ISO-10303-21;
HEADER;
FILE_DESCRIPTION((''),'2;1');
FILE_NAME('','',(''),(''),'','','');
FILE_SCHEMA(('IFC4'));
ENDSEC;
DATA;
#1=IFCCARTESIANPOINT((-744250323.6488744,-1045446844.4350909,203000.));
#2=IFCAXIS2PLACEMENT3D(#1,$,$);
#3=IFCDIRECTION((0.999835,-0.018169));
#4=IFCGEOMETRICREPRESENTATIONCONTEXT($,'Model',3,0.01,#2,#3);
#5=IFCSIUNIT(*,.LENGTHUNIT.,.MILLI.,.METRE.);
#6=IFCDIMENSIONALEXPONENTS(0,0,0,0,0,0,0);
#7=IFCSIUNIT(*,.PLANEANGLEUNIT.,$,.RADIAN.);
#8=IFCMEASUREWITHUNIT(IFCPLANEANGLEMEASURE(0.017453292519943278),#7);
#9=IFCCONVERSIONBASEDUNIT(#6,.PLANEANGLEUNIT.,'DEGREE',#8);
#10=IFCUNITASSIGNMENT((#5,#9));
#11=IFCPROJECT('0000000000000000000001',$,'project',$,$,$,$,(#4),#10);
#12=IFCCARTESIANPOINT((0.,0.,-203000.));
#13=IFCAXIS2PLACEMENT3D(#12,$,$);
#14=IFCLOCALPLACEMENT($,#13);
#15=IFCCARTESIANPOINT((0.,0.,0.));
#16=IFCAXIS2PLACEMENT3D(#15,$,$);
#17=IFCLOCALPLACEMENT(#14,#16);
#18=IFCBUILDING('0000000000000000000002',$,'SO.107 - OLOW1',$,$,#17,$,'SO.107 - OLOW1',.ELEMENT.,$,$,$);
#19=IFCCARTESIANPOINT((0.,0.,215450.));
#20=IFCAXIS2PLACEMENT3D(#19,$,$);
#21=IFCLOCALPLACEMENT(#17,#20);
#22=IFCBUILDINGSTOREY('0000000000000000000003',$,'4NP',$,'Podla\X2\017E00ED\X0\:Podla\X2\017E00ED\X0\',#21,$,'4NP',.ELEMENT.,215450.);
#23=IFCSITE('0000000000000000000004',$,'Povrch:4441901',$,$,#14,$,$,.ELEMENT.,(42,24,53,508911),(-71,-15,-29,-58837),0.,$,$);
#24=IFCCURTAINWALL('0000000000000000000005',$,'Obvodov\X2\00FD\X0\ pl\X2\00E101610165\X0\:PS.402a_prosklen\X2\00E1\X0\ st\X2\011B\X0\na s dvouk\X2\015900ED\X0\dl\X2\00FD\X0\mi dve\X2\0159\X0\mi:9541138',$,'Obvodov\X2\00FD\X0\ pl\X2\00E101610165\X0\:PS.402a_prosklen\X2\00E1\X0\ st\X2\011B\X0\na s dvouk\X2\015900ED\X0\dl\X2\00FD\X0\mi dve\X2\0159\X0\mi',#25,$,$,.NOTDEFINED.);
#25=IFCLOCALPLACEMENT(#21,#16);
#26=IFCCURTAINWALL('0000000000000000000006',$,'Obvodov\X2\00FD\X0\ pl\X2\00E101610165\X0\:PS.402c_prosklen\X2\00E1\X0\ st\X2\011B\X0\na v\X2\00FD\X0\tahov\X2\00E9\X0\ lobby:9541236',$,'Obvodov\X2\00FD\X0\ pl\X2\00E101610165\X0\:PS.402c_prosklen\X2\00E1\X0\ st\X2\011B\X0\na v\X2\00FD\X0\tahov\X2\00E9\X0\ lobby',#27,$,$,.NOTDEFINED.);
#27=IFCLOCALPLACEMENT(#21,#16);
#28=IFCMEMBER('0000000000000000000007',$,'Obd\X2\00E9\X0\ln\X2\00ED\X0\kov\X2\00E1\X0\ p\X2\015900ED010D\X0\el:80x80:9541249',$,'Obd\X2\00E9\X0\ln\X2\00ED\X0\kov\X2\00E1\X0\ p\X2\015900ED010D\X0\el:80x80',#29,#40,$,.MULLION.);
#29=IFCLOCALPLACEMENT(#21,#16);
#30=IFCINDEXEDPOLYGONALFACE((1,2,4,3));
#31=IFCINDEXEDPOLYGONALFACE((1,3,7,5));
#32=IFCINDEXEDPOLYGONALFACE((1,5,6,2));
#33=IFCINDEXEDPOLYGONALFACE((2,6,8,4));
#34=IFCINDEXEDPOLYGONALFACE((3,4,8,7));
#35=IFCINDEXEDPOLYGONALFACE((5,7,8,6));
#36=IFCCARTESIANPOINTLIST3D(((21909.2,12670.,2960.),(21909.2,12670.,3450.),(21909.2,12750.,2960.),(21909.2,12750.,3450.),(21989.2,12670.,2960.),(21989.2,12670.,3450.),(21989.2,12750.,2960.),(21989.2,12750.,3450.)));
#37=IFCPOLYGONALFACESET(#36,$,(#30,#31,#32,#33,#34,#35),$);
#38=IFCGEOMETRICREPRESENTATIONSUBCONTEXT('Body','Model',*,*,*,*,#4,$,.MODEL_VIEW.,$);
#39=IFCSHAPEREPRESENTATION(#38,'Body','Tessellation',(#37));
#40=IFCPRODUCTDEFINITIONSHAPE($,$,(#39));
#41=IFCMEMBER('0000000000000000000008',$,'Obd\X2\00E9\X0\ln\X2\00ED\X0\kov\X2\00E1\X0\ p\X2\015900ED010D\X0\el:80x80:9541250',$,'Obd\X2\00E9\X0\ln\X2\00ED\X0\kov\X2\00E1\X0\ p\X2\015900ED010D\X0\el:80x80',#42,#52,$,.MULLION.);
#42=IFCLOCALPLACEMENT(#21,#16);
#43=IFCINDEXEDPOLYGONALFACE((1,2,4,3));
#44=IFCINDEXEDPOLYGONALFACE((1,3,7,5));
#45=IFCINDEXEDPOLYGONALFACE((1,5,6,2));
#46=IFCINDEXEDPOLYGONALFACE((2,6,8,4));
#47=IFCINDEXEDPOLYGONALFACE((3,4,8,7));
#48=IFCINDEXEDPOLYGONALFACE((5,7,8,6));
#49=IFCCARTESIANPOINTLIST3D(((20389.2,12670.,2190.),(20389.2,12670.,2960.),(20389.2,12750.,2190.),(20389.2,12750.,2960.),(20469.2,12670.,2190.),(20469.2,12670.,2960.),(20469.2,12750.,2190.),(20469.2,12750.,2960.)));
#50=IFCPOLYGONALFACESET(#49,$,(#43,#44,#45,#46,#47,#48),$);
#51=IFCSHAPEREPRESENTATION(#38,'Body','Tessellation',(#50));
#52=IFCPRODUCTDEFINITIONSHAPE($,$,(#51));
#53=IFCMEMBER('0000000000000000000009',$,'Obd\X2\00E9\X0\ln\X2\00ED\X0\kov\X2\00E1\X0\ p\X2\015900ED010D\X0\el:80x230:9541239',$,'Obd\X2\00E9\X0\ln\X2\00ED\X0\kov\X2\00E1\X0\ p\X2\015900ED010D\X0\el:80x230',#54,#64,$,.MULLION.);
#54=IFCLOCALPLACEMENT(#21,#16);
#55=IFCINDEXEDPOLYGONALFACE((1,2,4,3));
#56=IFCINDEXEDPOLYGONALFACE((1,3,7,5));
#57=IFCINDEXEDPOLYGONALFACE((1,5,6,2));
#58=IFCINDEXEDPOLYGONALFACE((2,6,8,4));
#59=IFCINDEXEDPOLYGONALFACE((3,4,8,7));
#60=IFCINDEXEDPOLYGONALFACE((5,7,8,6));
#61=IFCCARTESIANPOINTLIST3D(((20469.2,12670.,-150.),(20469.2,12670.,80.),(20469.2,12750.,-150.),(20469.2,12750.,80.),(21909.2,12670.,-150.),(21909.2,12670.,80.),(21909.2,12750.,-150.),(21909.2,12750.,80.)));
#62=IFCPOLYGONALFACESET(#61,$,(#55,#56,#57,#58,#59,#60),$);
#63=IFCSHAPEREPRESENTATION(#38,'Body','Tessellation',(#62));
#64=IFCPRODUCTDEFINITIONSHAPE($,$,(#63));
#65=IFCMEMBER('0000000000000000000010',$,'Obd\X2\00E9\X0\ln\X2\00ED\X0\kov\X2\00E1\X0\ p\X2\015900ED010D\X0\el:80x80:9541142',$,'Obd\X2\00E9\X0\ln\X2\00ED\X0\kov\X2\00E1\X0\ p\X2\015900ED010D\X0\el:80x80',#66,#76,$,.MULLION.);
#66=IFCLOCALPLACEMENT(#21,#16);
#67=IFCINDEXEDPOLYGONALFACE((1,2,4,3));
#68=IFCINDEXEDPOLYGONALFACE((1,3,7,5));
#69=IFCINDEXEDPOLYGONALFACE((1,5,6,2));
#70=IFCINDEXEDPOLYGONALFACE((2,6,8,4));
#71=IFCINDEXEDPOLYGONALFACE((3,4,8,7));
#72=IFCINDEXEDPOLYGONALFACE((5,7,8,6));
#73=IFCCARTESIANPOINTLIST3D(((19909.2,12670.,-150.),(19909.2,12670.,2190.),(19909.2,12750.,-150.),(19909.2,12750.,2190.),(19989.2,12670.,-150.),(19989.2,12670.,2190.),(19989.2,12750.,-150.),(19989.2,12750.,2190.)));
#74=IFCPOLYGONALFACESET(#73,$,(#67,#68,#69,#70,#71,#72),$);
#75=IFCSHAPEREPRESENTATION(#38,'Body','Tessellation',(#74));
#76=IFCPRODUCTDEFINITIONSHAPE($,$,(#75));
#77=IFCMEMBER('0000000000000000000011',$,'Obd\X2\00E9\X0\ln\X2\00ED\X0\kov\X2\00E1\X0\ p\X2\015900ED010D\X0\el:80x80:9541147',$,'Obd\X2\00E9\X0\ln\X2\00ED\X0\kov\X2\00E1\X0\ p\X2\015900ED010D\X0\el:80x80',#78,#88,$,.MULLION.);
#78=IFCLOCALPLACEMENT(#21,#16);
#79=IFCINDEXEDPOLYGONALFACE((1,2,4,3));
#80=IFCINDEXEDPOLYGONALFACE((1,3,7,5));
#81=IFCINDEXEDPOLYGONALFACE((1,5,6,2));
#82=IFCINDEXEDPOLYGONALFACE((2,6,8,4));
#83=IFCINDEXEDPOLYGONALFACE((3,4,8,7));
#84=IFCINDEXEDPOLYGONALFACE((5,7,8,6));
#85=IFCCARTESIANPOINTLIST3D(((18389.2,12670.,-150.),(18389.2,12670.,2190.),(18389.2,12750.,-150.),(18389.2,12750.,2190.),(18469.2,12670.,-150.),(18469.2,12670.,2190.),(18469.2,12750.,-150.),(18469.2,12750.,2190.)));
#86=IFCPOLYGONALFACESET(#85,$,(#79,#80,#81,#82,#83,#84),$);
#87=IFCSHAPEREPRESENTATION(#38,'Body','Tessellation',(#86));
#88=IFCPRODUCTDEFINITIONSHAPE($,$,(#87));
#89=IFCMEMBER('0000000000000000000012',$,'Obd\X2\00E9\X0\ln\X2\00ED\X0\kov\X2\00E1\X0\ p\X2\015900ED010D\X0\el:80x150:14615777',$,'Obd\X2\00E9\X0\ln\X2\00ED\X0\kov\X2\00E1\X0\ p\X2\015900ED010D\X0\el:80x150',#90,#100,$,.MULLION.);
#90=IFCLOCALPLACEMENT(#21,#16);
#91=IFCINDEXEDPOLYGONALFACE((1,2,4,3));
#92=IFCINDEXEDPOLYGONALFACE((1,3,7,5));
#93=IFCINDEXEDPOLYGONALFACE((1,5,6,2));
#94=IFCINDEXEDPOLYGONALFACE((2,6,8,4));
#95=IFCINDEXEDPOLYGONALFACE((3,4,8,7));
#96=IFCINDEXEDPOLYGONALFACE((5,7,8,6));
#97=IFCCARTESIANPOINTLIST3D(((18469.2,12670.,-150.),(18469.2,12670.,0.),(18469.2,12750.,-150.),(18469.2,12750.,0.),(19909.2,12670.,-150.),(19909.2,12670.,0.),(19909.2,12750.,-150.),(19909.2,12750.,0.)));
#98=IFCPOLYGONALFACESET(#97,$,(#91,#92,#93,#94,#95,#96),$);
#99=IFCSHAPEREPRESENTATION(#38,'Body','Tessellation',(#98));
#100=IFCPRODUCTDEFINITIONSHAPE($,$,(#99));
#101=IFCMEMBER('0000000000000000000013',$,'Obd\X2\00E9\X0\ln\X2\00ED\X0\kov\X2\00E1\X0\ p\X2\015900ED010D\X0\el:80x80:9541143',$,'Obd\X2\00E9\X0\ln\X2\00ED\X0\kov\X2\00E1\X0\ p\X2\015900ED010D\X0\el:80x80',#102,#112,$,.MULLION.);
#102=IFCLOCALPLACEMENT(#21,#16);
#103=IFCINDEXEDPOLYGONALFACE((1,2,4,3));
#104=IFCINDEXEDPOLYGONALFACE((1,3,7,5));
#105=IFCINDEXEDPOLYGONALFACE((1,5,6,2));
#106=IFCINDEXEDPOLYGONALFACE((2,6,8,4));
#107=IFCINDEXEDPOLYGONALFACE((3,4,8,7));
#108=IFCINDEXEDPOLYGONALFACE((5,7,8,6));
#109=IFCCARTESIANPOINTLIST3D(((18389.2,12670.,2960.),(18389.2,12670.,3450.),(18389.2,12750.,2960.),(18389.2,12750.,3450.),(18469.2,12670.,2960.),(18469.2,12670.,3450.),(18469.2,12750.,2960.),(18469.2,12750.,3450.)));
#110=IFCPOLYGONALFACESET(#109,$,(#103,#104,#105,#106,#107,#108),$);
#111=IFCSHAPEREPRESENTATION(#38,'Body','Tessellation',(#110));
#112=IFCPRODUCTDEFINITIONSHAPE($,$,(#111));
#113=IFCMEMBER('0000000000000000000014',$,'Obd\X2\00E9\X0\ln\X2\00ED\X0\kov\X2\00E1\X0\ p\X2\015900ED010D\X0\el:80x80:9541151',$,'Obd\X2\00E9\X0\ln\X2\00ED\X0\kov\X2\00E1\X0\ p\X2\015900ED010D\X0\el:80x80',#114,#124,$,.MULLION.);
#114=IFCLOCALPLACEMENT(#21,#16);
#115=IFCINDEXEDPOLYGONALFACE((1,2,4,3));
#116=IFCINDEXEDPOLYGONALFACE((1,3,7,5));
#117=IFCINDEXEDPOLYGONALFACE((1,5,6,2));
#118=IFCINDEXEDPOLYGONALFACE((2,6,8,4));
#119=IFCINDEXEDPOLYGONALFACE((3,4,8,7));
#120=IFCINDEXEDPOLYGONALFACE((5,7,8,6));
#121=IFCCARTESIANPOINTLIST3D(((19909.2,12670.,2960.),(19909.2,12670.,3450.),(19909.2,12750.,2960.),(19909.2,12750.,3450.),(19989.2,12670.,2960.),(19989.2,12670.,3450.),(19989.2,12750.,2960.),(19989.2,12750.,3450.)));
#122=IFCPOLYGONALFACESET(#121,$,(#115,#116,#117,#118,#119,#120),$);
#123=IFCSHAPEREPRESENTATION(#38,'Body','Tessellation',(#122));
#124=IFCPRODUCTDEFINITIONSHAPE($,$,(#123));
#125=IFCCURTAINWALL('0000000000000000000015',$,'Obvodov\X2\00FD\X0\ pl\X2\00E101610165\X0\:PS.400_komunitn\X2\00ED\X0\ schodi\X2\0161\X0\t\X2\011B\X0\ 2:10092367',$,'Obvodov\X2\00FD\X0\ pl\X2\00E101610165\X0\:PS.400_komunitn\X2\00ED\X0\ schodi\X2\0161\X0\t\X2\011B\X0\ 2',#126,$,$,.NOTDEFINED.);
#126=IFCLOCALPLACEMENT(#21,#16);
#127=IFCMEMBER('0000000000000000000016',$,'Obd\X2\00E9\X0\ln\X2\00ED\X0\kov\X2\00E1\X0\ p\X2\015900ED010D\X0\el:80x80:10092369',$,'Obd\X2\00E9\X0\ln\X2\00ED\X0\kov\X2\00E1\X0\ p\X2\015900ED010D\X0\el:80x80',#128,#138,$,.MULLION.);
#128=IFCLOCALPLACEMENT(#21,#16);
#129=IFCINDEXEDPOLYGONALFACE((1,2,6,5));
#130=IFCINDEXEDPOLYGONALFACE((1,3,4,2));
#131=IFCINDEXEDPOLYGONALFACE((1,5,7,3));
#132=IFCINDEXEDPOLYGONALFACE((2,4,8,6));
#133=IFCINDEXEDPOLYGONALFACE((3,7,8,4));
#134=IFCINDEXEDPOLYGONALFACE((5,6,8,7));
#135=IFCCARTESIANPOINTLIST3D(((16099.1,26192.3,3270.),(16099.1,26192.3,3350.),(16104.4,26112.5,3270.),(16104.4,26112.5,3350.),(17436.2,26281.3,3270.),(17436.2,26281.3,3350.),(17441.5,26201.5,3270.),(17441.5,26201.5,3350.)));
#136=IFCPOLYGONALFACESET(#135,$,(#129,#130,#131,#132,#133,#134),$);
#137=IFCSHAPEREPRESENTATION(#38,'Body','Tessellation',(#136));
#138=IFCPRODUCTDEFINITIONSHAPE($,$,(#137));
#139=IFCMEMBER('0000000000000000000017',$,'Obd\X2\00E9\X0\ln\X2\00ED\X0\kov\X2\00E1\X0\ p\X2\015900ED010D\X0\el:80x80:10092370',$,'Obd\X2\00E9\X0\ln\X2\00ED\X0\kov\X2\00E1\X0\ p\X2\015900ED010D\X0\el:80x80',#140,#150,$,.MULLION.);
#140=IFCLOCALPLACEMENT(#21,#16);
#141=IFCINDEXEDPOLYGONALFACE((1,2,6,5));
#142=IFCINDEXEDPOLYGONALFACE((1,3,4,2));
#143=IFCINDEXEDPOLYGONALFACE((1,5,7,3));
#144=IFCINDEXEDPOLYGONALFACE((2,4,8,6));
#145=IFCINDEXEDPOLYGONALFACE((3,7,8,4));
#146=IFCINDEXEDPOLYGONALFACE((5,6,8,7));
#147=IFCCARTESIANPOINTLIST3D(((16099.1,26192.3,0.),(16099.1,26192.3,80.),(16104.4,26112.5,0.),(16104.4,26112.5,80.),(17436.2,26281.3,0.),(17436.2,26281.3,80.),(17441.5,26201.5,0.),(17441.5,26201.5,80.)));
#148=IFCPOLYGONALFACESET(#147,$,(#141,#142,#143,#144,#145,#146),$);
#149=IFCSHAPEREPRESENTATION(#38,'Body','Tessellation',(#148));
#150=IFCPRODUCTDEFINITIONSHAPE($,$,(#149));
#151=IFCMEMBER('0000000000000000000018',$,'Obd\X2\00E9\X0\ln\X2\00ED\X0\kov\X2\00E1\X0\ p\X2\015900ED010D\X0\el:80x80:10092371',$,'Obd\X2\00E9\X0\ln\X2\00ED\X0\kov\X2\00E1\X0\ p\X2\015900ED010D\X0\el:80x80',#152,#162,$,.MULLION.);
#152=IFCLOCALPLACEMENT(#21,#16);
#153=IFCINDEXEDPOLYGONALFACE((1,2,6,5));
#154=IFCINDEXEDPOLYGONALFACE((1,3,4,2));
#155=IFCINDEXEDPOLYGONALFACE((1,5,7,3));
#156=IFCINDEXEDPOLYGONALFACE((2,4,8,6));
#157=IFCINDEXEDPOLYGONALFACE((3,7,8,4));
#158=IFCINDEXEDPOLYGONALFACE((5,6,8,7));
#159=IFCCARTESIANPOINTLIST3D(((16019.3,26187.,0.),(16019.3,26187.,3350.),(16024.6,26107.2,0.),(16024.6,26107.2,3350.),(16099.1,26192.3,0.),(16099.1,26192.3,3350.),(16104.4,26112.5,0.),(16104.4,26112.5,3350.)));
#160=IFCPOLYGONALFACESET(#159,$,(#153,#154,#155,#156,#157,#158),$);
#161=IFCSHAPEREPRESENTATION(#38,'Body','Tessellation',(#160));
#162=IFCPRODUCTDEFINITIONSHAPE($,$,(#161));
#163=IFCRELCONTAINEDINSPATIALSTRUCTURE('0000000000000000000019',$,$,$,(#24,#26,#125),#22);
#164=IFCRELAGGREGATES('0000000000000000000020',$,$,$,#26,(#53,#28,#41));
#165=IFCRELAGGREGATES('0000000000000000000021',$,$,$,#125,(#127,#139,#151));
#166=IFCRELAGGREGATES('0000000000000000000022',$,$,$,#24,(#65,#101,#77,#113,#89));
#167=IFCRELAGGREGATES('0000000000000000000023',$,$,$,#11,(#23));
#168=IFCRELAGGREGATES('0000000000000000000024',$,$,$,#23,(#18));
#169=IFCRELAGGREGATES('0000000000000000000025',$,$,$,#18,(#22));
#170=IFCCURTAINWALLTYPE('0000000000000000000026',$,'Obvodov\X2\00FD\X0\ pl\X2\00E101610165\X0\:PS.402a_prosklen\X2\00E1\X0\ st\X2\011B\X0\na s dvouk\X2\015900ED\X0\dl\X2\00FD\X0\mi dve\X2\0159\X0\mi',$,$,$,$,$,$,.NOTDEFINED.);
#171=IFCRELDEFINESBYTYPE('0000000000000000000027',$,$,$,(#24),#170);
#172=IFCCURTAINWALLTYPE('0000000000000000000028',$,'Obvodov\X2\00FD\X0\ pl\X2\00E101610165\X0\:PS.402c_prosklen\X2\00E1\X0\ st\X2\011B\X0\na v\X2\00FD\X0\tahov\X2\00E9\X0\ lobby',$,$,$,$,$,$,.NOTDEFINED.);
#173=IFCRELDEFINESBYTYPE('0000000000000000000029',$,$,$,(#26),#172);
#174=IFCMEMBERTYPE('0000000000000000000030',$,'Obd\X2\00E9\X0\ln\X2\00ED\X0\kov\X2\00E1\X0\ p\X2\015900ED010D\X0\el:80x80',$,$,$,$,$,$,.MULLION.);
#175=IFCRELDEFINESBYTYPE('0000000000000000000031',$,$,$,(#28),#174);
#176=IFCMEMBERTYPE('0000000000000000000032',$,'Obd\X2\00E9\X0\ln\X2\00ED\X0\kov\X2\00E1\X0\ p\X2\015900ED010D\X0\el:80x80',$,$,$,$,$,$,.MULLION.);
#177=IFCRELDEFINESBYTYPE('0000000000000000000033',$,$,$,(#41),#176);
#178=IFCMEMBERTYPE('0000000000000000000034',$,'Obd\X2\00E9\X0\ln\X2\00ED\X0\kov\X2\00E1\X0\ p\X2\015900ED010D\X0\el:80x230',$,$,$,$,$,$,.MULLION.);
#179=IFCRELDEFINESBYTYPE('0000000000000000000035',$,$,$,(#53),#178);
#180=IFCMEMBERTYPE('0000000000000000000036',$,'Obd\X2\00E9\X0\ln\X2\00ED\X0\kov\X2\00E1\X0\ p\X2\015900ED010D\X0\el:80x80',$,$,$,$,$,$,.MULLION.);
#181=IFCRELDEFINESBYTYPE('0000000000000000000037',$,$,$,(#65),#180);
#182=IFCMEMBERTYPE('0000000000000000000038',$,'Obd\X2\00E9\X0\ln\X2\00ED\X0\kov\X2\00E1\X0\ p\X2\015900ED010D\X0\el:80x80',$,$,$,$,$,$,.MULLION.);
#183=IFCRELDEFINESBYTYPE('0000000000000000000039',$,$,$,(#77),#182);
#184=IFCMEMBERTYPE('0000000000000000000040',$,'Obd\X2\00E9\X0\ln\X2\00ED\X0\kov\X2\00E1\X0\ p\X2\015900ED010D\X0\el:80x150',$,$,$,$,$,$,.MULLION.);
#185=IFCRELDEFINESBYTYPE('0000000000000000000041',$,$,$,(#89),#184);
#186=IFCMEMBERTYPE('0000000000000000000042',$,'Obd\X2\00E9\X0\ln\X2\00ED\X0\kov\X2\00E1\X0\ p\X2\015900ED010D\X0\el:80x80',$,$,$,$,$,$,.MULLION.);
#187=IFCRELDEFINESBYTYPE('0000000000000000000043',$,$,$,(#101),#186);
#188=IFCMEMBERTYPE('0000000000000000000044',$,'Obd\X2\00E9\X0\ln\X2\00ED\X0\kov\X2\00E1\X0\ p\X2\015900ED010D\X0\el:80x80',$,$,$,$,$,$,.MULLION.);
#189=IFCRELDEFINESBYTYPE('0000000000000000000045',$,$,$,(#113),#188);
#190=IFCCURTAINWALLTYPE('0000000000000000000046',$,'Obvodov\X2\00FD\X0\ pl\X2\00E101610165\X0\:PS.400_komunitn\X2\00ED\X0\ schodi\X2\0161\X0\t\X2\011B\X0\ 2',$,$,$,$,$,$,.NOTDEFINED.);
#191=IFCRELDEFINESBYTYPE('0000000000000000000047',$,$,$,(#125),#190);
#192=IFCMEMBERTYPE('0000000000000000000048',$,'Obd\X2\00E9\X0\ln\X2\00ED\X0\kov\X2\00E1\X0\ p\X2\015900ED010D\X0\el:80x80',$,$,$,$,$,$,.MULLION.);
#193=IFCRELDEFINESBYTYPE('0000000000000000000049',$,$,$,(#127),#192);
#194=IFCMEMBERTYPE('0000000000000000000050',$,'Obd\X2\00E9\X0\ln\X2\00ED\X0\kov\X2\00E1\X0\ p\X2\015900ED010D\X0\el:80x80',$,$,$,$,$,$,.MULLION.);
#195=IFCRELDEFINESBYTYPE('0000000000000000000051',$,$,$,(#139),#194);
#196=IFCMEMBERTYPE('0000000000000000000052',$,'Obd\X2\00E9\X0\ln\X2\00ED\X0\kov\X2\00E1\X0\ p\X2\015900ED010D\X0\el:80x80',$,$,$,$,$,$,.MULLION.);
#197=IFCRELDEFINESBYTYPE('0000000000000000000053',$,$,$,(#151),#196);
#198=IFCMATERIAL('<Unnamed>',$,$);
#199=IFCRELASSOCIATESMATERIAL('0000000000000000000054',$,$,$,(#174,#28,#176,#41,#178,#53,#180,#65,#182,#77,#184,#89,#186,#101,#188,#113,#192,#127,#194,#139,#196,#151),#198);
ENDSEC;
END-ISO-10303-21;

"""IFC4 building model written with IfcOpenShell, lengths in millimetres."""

from ifc_helpers import new_model, entity, si_unit, converted_unit, direction, frame, origin, place, context, subcontext, project, spatial, indexed_curve, outline, extrude, source, transform, mapped, material, type_object, type_shapes, element, aggregate, save


model = new_model("IFC4")

# Units and contexts
model_context = context("Model", 3, precision=0.01, world=frame((-744250323.6488744, -1045446844.4350909, 203000.0)), true_north=direction((0.999835, -0.018169)))
body_context = subcontext(model_context, "Body", "Model", "MODEL_VIEW")
ifc_project = project(units=[si_unit("LENGTHUNIT", "METRE", prefix="MILLI"), converted_unit("PLANEANGLEUNIT", "DEGREE", entity("IfcPlaneAngleMeasure", 0.017453292519943278), si_unit("PLANEANGLEUNIT", "RADIAN"), dimensions=[0, 0, 0, 0, 0, 0, 0])], contexts=[model_context])

# Site, building, storey
site_placement = place(None, frame((0.0, 0.0, -203000.0)))
site = spatial("IfcSite", under=ifc_project, at=site_placement, Name="Povrch:4441901", CompositionType="ELEMENT", RefLatitude=(42, 24, 53, 508911), RefLongitude=(-71, -15, -29, -58837), RefElevation=0.0)
building_placement = place(site_placement, origin())
building = spatial("IfcBuilding", under=site, at=building_placement, Name="SO.107 - OLOW1", LongName="SO.107 - OLOW1", CompositionType="ELEMENT")
storey_placement = place(building_placement, frame((0.0, 0.0, 215450.0)))
storey = spatial("IfcBuildingStorey", under=building, at=storey_placement, Name="4NP", ObjectType="Podlaží:Podlaží", LongName="4NP", CompositionType="ELEMENT", Elevation=215450.0)

# Curtain walls, members
curtain_wall_type_1 = type_object("IfcCurtainWallType", Name="Obvodový plášť:PS.402a_prosklená stěna s dvoukřídlými dveřmi", PredefinedType="NOTDEFINED")
curtain_wall_1_placement = place(storey_placement, frame((0.0, 0.0, -215450.0)))
curtain_wall_1 = element("IfcCurtainWall", 1, at=curtain_wall_1_placement, inside=storey, type_object=curtain_wall_type_1, Name="Obvodový plášť:PS.402a_prosklená stěna s dvoukřídlými dveřmi:9541138", ObjectType="Obvodový plášť:PS.402a_prosklená stěna s dvoukřídlými dveřmi", PredefinedType="NOTDEFINED")
ifc_material_1 = material(Name="<Unnamed>")
curtain_wall_type_2 = type_object("IfcCurtainWallType", Name="Obvodový plášť:PS.402c_prosklená stěna výtahové lobby", PredefinedType="NOTDEFINED")
curtain_wall_2_placement = place(storey_placement, frame((0.0, 0.0, -215450.0)))
curtain_wall_2 = element("IfcCurtainWall", 2, at=curtain_wall_2_placement, inside=storey, type_object=curtain_wall_type_2, Name="Obvodový plášť:PS.402c_prosklená stěna výtahové lobby:9541236", ObjectType="Obvodový plášť:PS.402c_prosklená stěna výtahové lobby", PredefinedType="NOTDEFINED")
member_type_1 = type_object("IfcMemberType", Name="Obdélníková příčel:80x80", PredefinedType="MULLION", material=ifc_material_1)
shared_shape_1 = source(origin(), body_context, "Body", "SweptSolid", [
    extrude(outline(indexed_curve([(-40.0, -40.0), (40.0, -40.0), (40.0, 40.0), (-40.0, 40.0), (-40.0, -40.0)], self_intersect=False)), frame((-40.0, 0.0, -490.0), z_axis=(0.0, 0.0, 1.0), x_axis=(-1.0, 0.0, 0.0)), (0.0, 0.0, 1.0), 490.0),
])
type_shapes(member_type_1, [shared_shape_1])
member_1_placement = place(curtain_wall_2_placement, frame((21989.2, 12710.0, 218410.0), z_axis=(0.0, 0.0, -1.0), x_axis=(1.0, 0.0, 0.0)))
member_1 = element("IfcMember", 3, at=member_1_placement, type_object=member_type_1, material=ifc_material_1, Name="Obdélníková příčel:80x80:9541249", ObjectType="Obdélníková příčel:80x80", PredefinedType="MULLION", context=body_context, shape_type="MappedRepresentation", body=[
    mapped(shared_shape_1, transform((0.0, 0.0, 0.0), scale=1.0)),
])
member_type_2 = type_object("IfcMemberType", Name="Obdélníková příčel:80x80", PredefinedType="MULLION", material=ifc_material_1)
shared_shape_2 = source(origin(), body_context, "Body", "SweptSolid", [
    extrude(outline(indexed_curve([(-40.0, -40.0), (40.0, -40.0), (40.0, 40.0), (-40.0, 40.0), (-40.0, -40.0)], self_intersect=False)), frame((-40.0, 0.0, -770.0), z_axis=(0.0, 0.0, 1.0), x_axis=(-1.0, 0.0, 0.0)), (0.0, 0.0, 1.0), 770.0),
])
type_shapes(member_type_2, [shared_shape_2])
member_2_placement = place(curtain_wall_2_placement, frame((20389.2, 12710.0, 218410.0), z_axis=(0.0, 0.0, 1.0), x_axis=(-1.0, 0.0, 0.0)))
member_2 = element("IfcMember", 4, at=member_2_placement, type_object=member_type_2, material=ifc_material_1, Name="Obdélníková příčel:80x80:9541250", ObjectType="Obdélníková příčel:80x80", PredefinedType="MULLION", context=body_context, shape_type="MappedRepresentation", body=[
    mapped(shared_shape_2, transform((0.0, 0.0, 0.0), scale=1.0)),
])
member_type_3 = type_object("IfcMemberType", Name="Obdélníková příčel:80x230", PredefinedType="MULLION", material=ifc_material_1)
shared_shape_3 = source(origin(), body_context, "Body", "SweptSolid", [
    extrude(outline(indexed_curve([(-115.0, -40.0), (115.0, -40.0), (115.0, 40.0), (-115.0, 40.0), (-115.0, -40.0)], self_intersect=False)), frame((-115.0, 0.0, -1440.0), z_axis=(0.0, 0.0, 1.0), x_axis=(-1.0, 0.0, 0.0)), (0.0, 0.0, 1.0), 1440.0),
])
type_shapes(member_type_3, [shared_shape_3])
member_3_placement = place(curtain_wall_2_placement, frame((20469.2, 12710.0, 215300.0), z_axis=(-1.0, 0.0, 0.0), x_axis=(0.0, 0.0, -1.0)))
member_3 = element("IfcMember", 5, at=member_3_placement, type_object=member_type_3, material=ifc_material_1, Name="Obdélníková příčel:80x230:9541239", ObjectType="Obdélníková příčel:80x230", PredefinedType="MULLION", context=body_context, shape_type="MappedRepresentation", body=[
    mapped(shared_shape_3, transform((0.0, 0.0, 0.0), scale=1.0)),
])

# Members
member_type_4 = type_object("IfcMemberType", Name="Obdélníková příčel:80x80", PredefinedType="MULLION", material=ifc_material_1)
shared_shape_4 = source(origin(), body_context, "Body", "SweptSolid", [
    extrude(outline(indexed_curve([(-40.0, -40.0), (40.0, -40.0), (40.0, 40.0), (-40.0, 40.0), (-40.0, -40.0)], self_intersect=False)), frame((-40.0, 0.0, -2340.0), z_axis=(0.0, 0.0, 1.0), x_axis=(-1.0, 0.0, 0.0)), (0.0, 0.0, 1.0), 2340.0),
])
type_shapes(member_type_4, [shared_shape_4])
member_4_placement = place(curtain_wall_1_placement, frame((19989.2, 12710.0, 215300.0), z_axis=(0.0, 0.0, -1.0), x_axis=(1.0, 0.0, 0.0)))
member_4 = element("IfcMember", 6, at=member_4_placement, type_object=member_type_4, material=ifc_material_1, Name="Obdélníková příčel:80x80:9541142", ObjectType="Obdélníková příčel:80x80", PredefinedType="MULLION", context=body_context, shape_type="MappedRepresentation", body=[
    mapped(shared_shape_4, transform((0.0, 0.0, 0.0), scale=1.0)),
])
member_type_5 = type_object("IfcMemberType", Name="Obdélníková příčel:80x80", PredefinedType="MULLION", material=ifc_material_1)
shared_shape_5 = source(origin(), body_context, "Body", "SweptSolid", [
    extrude(outline(indexed_curve([(-40.0, -40.0), (40.0, -40.0), (40.0, 40.0), (-40.0, 40.0), (-40.0, -40.0)], self_intersect=False)), frame((-40.0, 0.0, -2340.0), z_axis=(0.0, 0.0, 1.0), x_axis=(-1.0, 0.0, 0.0)), (0.0, 0.0, 1.0), 2340.0),
])
type_shapes(member_type_5, [shared_shape_5])
member_5_placement = place(curtain_wall_1_placement, frame((18389.2, 12710.0, 217640.0), z_axis=(0.0, 0.0, 1.0), x_axis=(-1.0, 0.0, 0.0)))
member_5 = element("IfcMember", 7, at=member_5_placement, type_object=member_type_5, material=ifc_material_1, Name="Obdélníková příčel:80x80:9541147", ObjectType="Obdélníková příčel:80x80", PredefinedType="MULLION", context=body_context, shape_type="MappedRepresentation", body=[
    mapped(shared_shape_5, transform((0.0, 0.0, 0.0), scale=1.0)),
])
member_type_6 = type_object("IfcMemberType", Name="Obdélníková příčel:80x150", PredefinedType="MULLION", material=ifc_material_1)
shared_shape_6 = source(origin(), body_context, "Body", "SweptSolid", [
    extrude(outline(indexed_curve([(-75.0, -40.0), (75.0, -40.0), (75.0, 40.0), (-75.0, 40.0), (-75.0, -40.0)], self_intersect=False)), frame((-75.0, 0.0, -1440.0), z_axis=(0.0, 0.0, 1.0), x_axis=(-1.0, 0.0, 0.0)), (0.0, 0.0, 1.0), 1440.0),
])
type_shapes(member_type_6, [shared_shape_6])
member_6_placement = place(curtain_wall_1_placement, frame((18469.2, 12710.0, 215300.0), z_axis=(-1.0, 0.0, 0.0), x_axis=(0.0, 0.0, -1.0)))
member_6 = element("IfcMember", 8, at=member_6_placement, type_object=member_type_6, material=ifc_material_1, Name="Obdélníková příčel:80x150:14615777", ObjectType="Obdélníková příčel:80x150", PredefinedType="MULLION", context=body_context, shape_type="MappedRepresentation", body=[
    mapped(shared_shape_6, transform((0.0, 0.0, 0.0), scale=1.0)),
])
member_type_7 = type_object("IfcMemberType", Name="Obdélníková příčel:80x80", PredefinedType="MULLION", material=ifc_material_1)
shared_shape_7 = source(origin(), body_context, "Body", "SweptSolid", [
    extrude(outline(indexed_curve([(-40.0, -40.0), (40.0, -40.0), (40.0, 40.0), (-40.0, 40.0), (-40.0, -40.0)], self_intersect=False)), frame((-40.0, 0.0, -490.0), z_axis=(0.0, 0.0, 1.0), x_axis=(-1.0, 0.0, 0.0)), (0.0, 0.0, 1.0), 490.0),
])
type_shapes(member_type_7, [shared_shape_7])
member_7_placement = place(curtain_wall_1_placement, frame((18389.2, 12710.0, 218900.0), z_axis=(0.0, 0.0, 1.0), x_axis=(-1.0, 0.0, 0.0)))
member_7 = element("IfcMember", 9, at=member_7_placement, type_object=member_type_7, material=ifc_material_1, Name="Obdélníková příčel:80x80:9541143", ObjectType="Obdélníková příčel:80x80", PredefinedType="MULLION", context=body_context, shape_type="MappedRepresentation", body=[
    mapped(shared_shape_7, transform((0.0, 0.0, 0.0), scale=1.0)),
])
member_type_8 = type_object("IfcMemberType", Name="Obdélníková příčel:80x80", PredefinedType="MULLION", material=ifc_material_1)
shared_shape_8 = source(origin(), body_context, "Body", "SweptSolid", [
    extrude(outline(indexed_curve([(-40.0, -40.0), (40.0, -40.0), (40.0, 40.0), (-40.0, 40.0), (-40.0, -40.0)], self_intersect=False)), frame((-40.0, 0.0, -490.0), z_axis=(0.0, 0.0, 1.0), x_axis=(-1.0, 0.0, 0.0)), (0.0, 0.0, 1.0), 490.0),
])
type_shapes(member_type_8, [shared_shape_8])
member_8_placement = place(curtain_wall_1_placement, frame((19989.2, 12710.0, 218410.0), z_axis=(0.0, 0.0, -1.0), x_axis=(1.0, 0.0, 0.0)))
member_8 = element("IfcMember", 10, at=member_8_placement, type_object=member_type_8, material=ifc_material_1, Name="Obdélníková příčel:80x80:9541151", ObjectType="Obdélníková příčel:80x80", PredefinedType="MULLION", context=body_context, shape_type="MappedRepresentation", body=[
    mapped(shared_shape_8, transform((0.0, 0.0, 0.0), scale=1.0)),
])

# Curtain wall, members
curtain_wall_type_3 = type_object("IfcCurtainWallType", Name="Obvodový plášť:PS.400_komunitní schodiště 2", PredefinedType="NOTDEFINED")
curtain_wall_3_placement = place(storey_placement, frame((0.0, 0.0, -215450.0)))
curtain_wall_3 = element("IfcCurtainWall", 11, at=curtain_wall_3_placement, inside=storey, type_object=curtain_wall_type_3, Name="Obvodový plášť:PS.400_komunitní schodiště 2:10092367", ObjectType="Obvodový plášť:PS.400_komunitní schodiště 2", PredefinedType="NOTDEFINED")
member_type_9 = type_object("IfcMemberType", Name="Obdélníková příčel:80x80", PredefinedType="MULLION", material=ifc_material_1)
shared_shape_9 = source(origin(), body_context, "Body", "SweptSolid", [
    extrude(outline(indexed_curve([(-40.0, -40.0), (40.0, -40.0), (40.0, 40.0), (-40.0, 40.0), (-40.0, -40.0)], self_intersect=False)), frame((-40.0, 0.0, -1340.0), z_axis=(0.0, 0.0, 1.0), x_axis=(-1.0, 0.0, 0.0)), (0.0, 0.0, 1.0), 1340.0),
])
type_shapes(member_type_9, [shared_shape_9])
member_9_placement = place(curtain_wall_3_placement, frame((16101.8, 26152.4, 218800.0), z_axis=(-0.997792, -0.066409, 0.0), x_axis=(0.0, 0.0, 1.0)))
member_9 = element("IfcMember", 12, at=member_9_placement, type_object=member_type_9, material=ifc_material_1, Name="Obdélníková příčel:80x80:10092369", ObjectType="Obdélníková příčel:80x80", PredefinedType="MULLION", context=body_context, shape_type="MappedRepresentation", body=[
    mapped(shared_shape_9, transform((0.0, 0.0, 0.0), scale=1.0)),
])
member_type_10 = type_object("IfcMemberType", Name="Obdélníková příčel:80x80", PredefinedType="MULLION", material=ifc_material_1)
shared_shape_10 = source(origin(), body_context, "Body", "SweptSolid", [
    extrude(outline(indexed_curve([(-40.0, -40.0), (40.0, -40.0), (40.0, 40.0), (-40.0, 40.0), (-40.0, -40.0)], self_intersect=False)), frame((-40.0, 0.0, -1340.0), z_axis=(0.0, 0.0, 1.0), x_axis=(-1.0, 0.0, 0.0)), (0.0, 0.0, 1.0), 1340.0),
])
type_shapes(member_type_10, [shared_shape_10])
member_10_placement = place(curtain_wall_3_placement, frame((17438.8, 26241.4, 215450.0), z_axis=(0.997792, 0.066409, 0.0), x_axis=(0.0, 0.0, -1.0)))
member_10 = element("IfcMember", 13, at=member_10_placement, type_object=member_type_10, material=ifc_material_1, Name="Obdélníková příčel:80x80:10092370", ObjectType="Obdélníková příčel:80x80", PredefinedType="MULLION", context=body_context, shape_type="MappedRepresentation", body=[
    mapped(shared_shape_10, transform((0.0, 0.0, 0.0), scale=1.0)),
])
member_type_11 = type_object("IfcMemberType", Name="Obdélníková příčel:80x80", PredefinedType="MULLION", material=ifc_material_1)
shared_shape_11 = source(origin(), body_context, "Body", "SweptSolid", [
    extrude(outline(indexed_curve([(-40.0, -40.0), (40.0, -40.0), (40.0, 40.0), (-40.0, 40.0), (-40.0, -40.0)], self_intersect=False)), frame((-40.0, 0.0, -3350.0), z_axis=(0.0, 0.0, 1.0), x_axis=(-1.0, 0.0, 0.0)), (0.0, 0.0, 1.0), 3350.0),
])
type_shapes(member_type_11, [shared_shape_11])
member_11_placement = place(curtain_wall_3_placement, frame((16022.0, 26147.1, 215450.0), z_axis=(0.0, 0.0, -1.0), x_axis=(-0.997792, -0.066409, 0.0)))
member_11 = element("IfcMember", 14, at=member_11_placement, type_object=member_type_11, material=ifc_material_1, Name="Obdélníková příčel:80x80:10092371", ObjectType="Obdélníková příčel:80x80", PredefinedType="MULLION", context=body_context, shape_type="MappedRepresentation", body=[
    mapped(shared_shape_11, transform((0.0, 0.0, 0.0), scale=1.0)),
])

aggregate(curtain_wall_2, [member_3, member_1, member_2])
aggregate(curtain_wall_3, [member_9, member_10, member_11])

aggregate(curtain_wall_1, [member_4, member_7, member_5, member_8, member_6])

save(model, "model.ifc")
